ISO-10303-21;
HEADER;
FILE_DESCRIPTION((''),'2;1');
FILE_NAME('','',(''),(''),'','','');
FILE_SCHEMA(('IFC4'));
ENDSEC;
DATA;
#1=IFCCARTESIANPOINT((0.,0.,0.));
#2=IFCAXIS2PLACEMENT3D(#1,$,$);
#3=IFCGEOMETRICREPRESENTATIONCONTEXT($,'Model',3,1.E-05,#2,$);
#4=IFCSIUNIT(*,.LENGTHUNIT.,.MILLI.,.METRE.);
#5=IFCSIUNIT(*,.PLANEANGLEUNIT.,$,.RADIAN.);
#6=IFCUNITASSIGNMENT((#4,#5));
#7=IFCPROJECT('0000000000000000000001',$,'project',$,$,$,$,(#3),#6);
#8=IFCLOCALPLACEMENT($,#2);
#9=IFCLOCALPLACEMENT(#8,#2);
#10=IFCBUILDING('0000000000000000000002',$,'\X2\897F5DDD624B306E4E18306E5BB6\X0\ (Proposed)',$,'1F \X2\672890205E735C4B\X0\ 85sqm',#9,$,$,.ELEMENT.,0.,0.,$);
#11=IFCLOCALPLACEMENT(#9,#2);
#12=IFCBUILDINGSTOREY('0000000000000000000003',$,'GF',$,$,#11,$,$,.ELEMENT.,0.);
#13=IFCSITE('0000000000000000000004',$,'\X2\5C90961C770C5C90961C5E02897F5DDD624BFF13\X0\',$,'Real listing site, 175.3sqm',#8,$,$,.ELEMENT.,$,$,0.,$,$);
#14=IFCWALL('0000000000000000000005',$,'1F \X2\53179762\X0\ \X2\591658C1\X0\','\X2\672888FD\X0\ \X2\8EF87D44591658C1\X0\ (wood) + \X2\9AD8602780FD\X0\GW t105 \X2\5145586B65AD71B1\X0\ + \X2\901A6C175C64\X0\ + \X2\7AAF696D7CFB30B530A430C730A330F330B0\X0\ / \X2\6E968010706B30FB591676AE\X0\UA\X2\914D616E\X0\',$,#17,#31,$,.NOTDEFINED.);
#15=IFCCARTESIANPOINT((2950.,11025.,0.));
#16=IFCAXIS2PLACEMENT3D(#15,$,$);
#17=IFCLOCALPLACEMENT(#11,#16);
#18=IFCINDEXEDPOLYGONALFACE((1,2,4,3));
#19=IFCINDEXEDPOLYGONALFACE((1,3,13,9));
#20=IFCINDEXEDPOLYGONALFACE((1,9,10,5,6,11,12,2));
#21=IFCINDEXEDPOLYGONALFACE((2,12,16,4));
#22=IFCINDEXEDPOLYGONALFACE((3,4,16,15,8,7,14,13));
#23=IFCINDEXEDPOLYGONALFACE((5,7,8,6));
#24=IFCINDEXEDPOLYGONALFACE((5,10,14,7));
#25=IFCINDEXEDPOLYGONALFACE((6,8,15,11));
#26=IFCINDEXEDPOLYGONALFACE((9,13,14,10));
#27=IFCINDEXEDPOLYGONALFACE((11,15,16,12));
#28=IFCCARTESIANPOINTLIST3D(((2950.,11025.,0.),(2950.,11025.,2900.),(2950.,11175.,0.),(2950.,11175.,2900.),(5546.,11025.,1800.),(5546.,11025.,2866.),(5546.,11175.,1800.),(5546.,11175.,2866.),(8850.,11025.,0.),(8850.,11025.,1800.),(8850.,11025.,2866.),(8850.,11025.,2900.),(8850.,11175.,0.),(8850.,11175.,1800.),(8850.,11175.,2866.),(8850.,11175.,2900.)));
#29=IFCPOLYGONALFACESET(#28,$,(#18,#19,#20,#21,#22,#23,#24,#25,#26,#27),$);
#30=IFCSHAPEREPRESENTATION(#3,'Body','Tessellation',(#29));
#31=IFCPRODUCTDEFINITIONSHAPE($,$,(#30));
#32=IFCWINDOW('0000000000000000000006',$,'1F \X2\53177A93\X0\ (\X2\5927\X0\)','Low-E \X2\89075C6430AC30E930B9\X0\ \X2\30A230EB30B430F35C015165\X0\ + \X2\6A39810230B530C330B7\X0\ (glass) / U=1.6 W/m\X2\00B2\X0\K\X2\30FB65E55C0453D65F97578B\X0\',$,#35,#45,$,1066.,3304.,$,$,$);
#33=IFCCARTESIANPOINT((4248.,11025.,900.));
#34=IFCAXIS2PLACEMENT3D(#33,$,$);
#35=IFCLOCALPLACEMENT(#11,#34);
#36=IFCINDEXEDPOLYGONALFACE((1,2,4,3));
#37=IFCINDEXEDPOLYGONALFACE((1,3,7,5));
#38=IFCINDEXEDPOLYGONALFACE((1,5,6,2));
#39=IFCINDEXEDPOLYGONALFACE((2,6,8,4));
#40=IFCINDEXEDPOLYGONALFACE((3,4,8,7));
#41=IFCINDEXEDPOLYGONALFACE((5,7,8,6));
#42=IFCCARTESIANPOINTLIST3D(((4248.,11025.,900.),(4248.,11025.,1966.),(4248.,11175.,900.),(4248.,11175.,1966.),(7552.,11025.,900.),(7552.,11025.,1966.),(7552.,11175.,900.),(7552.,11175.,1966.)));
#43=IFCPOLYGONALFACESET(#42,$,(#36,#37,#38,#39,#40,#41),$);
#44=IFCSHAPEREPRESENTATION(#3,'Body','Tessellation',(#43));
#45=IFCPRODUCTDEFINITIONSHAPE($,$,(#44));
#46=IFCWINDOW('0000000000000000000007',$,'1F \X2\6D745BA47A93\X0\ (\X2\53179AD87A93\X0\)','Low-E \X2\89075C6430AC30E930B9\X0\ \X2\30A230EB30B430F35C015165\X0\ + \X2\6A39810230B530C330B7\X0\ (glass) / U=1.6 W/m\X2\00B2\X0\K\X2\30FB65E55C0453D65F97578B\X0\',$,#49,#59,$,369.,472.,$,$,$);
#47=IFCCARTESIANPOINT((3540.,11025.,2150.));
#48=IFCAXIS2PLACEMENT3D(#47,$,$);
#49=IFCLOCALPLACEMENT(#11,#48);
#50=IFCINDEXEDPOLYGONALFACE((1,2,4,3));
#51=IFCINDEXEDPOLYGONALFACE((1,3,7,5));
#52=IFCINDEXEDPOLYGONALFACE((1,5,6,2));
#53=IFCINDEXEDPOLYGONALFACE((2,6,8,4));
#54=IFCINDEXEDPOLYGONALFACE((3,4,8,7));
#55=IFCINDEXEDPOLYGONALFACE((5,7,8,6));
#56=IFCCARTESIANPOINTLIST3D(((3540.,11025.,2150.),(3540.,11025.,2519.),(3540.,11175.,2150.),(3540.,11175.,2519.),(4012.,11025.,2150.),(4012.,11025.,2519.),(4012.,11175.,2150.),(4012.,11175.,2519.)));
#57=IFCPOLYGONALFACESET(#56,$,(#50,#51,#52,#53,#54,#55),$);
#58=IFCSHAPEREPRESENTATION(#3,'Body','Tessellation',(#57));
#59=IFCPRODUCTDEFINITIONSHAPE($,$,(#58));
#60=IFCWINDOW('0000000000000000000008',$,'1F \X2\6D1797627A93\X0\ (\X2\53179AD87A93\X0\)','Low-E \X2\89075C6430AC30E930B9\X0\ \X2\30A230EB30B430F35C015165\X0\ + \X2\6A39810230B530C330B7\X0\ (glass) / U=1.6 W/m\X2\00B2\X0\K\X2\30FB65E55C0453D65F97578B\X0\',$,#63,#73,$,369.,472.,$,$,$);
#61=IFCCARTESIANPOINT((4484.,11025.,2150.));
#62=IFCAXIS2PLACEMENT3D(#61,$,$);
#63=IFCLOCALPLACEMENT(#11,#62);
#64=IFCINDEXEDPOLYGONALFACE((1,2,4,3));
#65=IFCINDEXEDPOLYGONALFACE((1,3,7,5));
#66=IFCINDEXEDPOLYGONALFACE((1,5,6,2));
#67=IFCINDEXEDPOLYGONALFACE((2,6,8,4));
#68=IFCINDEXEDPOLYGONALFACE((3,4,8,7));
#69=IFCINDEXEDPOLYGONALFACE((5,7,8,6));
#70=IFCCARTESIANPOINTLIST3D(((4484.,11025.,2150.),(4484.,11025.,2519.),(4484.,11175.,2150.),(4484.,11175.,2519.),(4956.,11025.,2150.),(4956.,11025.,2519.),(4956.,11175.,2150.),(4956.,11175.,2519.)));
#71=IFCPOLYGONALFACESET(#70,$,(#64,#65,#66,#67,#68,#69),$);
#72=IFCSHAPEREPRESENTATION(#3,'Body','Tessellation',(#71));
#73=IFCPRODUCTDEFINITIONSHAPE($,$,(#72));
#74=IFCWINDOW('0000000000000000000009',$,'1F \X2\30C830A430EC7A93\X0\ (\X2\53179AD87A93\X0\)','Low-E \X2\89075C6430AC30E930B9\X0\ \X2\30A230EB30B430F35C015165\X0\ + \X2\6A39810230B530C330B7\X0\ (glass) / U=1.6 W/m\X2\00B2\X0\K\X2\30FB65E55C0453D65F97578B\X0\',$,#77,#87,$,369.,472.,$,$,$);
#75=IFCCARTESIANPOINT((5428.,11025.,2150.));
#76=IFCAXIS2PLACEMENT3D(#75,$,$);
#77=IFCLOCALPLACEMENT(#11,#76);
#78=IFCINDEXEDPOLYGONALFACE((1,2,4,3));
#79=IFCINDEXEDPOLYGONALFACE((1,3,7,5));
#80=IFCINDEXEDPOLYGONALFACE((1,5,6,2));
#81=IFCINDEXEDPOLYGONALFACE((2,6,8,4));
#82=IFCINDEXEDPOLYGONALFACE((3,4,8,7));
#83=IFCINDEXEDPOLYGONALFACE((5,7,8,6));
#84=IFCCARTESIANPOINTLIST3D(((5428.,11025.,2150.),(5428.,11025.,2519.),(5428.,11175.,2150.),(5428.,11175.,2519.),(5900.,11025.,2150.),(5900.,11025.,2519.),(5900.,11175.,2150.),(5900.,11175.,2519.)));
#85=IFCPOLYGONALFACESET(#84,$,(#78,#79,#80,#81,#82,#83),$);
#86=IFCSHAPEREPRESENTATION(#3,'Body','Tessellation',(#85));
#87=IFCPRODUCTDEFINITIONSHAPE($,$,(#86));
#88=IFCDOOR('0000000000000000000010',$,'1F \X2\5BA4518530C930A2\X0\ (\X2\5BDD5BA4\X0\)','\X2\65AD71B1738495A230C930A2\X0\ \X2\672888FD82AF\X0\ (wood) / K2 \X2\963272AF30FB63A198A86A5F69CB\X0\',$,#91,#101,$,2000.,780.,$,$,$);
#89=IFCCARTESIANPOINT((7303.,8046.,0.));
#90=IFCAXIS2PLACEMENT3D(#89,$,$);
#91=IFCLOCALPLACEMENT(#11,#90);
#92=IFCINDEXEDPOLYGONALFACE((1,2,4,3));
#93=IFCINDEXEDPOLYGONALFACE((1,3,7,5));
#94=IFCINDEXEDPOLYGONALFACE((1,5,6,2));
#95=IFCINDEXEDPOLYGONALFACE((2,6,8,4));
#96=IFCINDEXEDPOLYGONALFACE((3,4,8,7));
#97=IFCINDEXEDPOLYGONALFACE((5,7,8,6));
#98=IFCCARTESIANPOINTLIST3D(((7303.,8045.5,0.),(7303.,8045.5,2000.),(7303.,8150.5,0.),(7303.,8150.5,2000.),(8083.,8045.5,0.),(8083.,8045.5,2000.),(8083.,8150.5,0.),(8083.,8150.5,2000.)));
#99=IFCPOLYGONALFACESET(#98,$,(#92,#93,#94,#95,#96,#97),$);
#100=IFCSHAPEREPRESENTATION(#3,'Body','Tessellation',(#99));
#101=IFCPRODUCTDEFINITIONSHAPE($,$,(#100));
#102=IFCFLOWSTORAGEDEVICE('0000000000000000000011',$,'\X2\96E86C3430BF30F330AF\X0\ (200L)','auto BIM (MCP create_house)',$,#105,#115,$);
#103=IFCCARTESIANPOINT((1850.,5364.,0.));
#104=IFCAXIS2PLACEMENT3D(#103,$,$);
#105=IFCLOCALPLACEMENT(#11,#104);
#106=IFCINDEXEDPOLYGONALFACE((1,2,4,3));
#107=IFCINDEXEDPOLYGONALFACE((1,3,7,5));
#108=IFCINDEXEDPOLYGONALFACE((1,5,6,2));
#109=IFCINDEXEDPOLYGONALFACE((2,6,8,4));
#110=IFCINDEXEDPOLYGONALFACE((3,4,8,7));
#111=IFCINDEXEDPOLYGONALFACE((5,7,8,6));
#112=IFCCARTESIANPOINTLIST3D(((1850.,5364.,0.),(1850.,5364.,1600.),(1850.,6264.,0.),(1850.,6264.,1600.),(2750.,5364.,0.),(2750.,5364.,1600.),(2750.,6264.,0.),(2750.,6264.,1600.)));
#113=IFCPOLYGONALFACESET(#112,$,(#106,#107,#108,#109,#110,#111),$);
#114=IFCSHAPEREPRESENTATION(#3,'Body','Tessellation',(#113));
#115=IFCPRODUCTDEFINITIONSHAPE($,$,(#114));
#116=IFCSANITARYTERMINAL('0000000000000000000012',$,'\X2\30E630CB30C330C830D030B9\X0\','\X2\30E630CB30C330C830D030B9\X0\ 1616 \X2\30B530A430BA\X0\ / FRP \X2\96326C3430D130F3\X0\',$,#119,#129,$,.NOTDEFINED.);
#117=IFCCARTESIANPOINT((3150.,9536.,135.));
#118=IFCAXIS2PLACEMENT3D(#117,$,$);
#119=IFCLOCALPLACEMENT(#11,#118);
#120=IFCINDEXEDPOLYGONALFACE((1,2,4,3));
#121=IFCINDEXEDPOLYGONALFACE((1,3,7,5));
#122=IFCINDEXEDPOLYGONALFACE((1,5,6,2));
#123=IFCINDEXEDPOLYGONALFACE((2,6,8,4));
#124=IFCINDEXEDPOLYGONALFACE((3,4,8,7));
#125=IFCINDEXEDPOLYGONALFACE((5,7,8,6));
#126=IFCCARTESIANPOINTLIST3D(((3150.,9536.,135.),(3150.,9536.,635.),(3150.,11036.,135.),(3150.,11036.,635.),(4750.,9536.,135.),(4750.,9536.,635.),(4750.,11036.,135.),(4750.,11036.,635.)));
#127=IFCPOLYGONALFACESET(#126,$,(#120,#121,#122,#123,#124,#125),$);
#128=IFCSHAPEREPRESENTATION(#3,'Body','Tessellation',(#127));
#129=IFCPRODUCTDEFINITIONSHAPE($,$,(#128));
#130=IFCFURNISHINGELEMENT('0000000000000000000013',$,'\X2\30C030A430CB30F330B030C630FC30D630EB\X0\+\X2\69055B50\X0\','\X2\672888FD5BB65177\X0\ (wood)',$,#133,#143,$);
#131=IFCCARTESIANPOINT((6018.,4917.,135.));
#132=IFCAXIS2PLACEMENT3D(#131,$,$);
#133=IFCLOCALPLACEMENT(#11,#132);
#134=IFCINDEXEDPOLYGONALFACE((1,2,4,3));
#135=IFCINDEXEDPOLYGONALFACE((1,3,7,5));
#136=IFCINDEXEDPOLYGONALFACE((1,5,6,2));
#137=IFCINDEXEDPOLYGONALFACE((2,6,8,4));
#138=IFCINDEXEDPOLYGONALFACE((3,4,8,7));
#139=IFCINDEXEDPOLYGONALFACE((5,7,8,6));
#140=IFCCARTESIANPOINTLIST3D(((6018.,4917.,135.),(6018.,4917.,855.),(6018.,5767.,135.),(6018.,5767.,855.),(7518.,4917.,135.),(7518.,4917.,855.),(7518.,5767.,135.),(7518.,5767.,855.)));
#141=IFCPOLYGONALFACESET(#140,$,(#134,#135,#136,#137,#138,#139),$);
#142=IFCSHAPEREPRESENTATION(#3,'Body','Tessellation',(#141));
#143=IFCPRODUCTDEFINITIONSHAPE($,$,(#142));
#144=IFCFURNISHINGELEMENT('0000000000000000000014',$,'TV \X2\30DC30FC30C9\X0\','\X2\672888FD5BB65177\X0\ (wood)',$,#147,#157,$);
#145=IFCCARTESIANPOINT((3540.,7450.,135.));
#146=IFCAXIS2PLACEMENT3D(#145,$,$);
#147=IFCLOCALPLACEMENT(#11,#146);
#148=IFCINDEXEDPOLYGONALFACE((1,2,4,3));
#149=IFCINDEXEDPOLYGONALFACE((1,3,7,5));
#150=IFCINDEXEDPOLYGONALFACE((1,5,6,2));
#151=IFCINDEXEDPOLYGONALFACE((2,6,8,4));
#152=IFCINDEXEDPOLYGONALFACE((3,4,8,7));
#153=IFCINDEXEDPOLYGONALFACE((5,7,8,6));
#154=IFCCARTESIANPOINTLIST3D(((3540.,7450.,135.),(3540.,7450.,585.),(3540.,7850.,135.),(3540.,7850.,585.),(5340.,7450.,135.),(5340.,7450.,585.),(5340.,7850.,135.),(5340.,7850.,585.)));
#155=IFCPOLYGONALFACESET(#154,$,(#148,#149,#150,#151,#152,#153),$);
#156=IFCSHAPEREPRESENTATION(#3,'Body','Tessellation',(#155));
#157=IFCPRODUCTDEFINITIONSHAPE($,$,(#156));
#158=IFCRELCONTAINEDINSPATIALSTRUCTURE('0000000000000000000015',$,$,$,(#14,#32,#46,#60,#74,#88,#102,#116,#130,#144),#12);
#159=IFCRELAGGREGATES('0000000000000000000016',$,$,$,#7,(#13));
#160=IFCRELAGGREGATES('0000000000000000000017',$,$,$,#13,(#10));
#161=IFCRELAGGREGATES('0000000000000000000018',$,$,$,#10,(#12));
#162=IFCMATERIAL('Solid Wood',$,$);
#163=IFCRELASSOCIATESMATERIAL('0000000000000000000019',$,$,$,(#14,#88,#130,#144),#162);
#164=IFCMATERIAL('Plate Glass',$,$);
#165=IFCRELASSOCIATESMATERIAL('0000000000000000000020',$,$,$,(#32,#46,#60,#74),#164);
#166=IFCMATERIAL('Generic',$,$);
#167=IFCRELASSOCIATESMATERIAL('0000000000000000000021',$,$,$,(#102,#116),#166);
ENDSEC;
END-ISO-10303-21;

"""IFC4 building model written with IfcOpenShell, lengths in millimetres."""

from ifc_helpers import new_model, si_unit, frame, frame_2d, origin, place, context, project, spatial, rectangle, extrude, material, element, fill, save


model = new_model("IFC4")

# Units and contexts
model_context = context("Model", 3, precision=1e-05, world=origin())
ifc_project = project(units=[si_unit("LENGTHUNIT", "METRE", prefix="MILLI"), si_unit("PLANEANGLEUNIT", "RADIAN")], contexts=[model_context])

# Site, building, storey
site_placement = place(None, origin())
site = spatial("IfcSite", under=ifc_project, at=site_placement, Name="岐阜県岐阜市西川手３", ObjectType="Real listing site, 175.3sqm", CompositionType="ELEMENT", RefElevation=0.0)
building_placement = place(site_placement, origin())
building = spatial("IfcBuilding", under=site, at=building_placement, Name="西川手の丘の家 (Proposed)", ObjectType="1F 木造平屋 85sqm", CompositionType="ELEMENT", ElevationOfRefHeight=0.0, ElevationOfTerrain=0.0)
storey_placement = place(building_placement, origin())
storey = spatial("IfcBuildingStorey", under=building, at=storey_placement, Name="GF", CompositionType="ELEMENT", Elevation=0.0)

# Wall, openings, windows
ifc_material_1 = material(Name="Solid Wood")
wall_1_placement = place(storey_placement, frame((2950.0, 11025.0, 0.0)))
wall_1 = element("IfcWall", 1, at=wall_1_placement, inside=storey, material=ifc_material_1, Name="1F 北面 外壁", Description="木製 軸組外壁 (wood) + 高性能GW t105 充填断熱 + 通気層 + 窯業系サイディング / 準耐火・外皮UA配慮", PredefinedType="NOTDEFINED", context=model_context, shape_type="SweptSolid", body=[
    extrude(rectangle(XDim=5900.0, YDim=150.0, at=frame_2d((2950.0, 75.0))), frame((2950.0, 11025.0, 0.0)), (0.0, 0.0, 1.0), 2900.0),
])
opening_1_placement = place(storey_placement, frame((4248.0, 11025.0, 900.0)))
opening_1 = element("IfcOpeningElement", 2, at=opening_1_placement, cuts=wall_1, PredefinedType="NOTDEFINED", context=model_context, shape_type="SweptSolid", body=[
    extrude(rectangle(XDim=3304.0, YDim=150.0, at=frame_2d((1652.0, 75.0))), frame((4248.0, 11025.0, 900.0)), (0.0, 0.0, 1.0), 1066.0),
])
opening_2_placement = place(storey_placement, frame((3540.0, 11025.0, 2150.0)))
opening_2 = element("IfcOpeningElement", 3, at=opening_2_placement, cuts=wall_1, PredefinedType="NOTDEFINED", context=model_context, shape_type="SweptSolid", body=[
    extrude(rectangle(XDim=472.0, YDim=150.0, at=frame_2d((236.0, 75.0))), frame((3540.0, 11025.0, 2150.0)), (0.0, 0.0, 1.0), 369.0),
])
opening_3_placement = place(storey_placement, frame((4484.0, 11025.0, 2150.0)))
opening_3 = element("IfcOpeningElement", 4, at=opening_3_placement, cuts=wall_1, PredefinedType="NOTDEFINED", context=model_context, shape_type="SweptSolid", body=[
    extrude(rectangle(XDim=472.0, YDim=150.0, at=frame_2d((236.0, 75.0))), frame((4484.0, 11025.0, 2150.0)), (0.0, 0.0, 1.0), 369.0),
])
opening_4_placement = place(storey_placement, frame((5428.0, 11025.0, 2150.0)))
opening_4 = element("IfcOpeningElement", 5, at=opening_4_placement, cuts=wall_1, PredefinedType="NOTDEFINED", context=model_context, shape_type="SweptSolid", body=[
    extrude(rectangle(XDim=472.0, YDim=150.0, at=frame_2d((236.0, 75.0))), frame((5428.0, 11025.0, 2150.0)), (0.0, 0.0, 1.0), 369.0),
])
ifc_material_2 = material(Name="Plate Glass")
window_1_placement = place(storey_placement, frame((4248.0, 11025.0, 900.0)))
window_1 = element("IfcWindow", 6, at=window_1_placement, inside=storey, material=ifc_material_2, Name="1F 北窓 (大)", Description="Low-E 複層ガラス アルゴン封入 + 樹脂サッシ (glass) / U=1.6 W/m²K・日射取得型", OverallHeight=1066.0, OverallWidth=3304.0, context=model_context, shape_type="SweptSolid", body=[
    extrude(rectangle(XDim=3304.0, YDim=150.0, at=frame_2d((1652.0, 75.0))), frame((4248.0, 11025.0, 900.0)), (0.0, 0.0, 1.0), 1066.0),
])
fill(opening_1, window_1)
window_2_placement = place(storey_placement, frame((3540.0, 11025.0, 2150.0)))
window_2 = element("IfcWindow", 7, at=window_2_placement, inside=storey, material=ifc_material_2, Name="1F 浴室窓 (北高窓)", Description="Low-E 複層ガラス アルゴン封入 + 樹脂サッシ (glass) / U=1.6 W/m²K・日射取得型", OverallHeight=369.0, OverallWidth=472.0, context=model_context, shape_type="SweptSolid", body=[
    extrude(rectangle(XDim=472.0, YDim=150.0, at=frame_2d((236.0, 75.0))), frame((3540.0, 11025.0, 2150.0)), (0.0, 0.0, 1.0), 369.0),
])
fill(opening_2, window_2)
window_3_placement = place(storey_placement, frame((4484.0, 11025.0, 2150.0)))
window_3 = element("IfcWindow", 8, at=window_3_placement, inside=storey, material=ifc_material_2, Name="1F 洗面窓 (北高窓)", Description="Low-E 複層ガラス アルゴン封入 + 樹脂サッシ (glass) / U=1.6 W/m²K・日射取得型", OverallHeight=369.0, OverallWidth=472.0, context=model_context, shape_type="SweptSolid", body=[
    extrude(rectangle(XDim=472.0, YDim=150.0, at=frame_2d((236.0, 75.0))), frame((4484.0, 11025.0, 2150.0)), (0.0, 0.0, 1.0), 369.0),
])
fill(opening_3, window_3)
window_4_placement = place(storey_placement, frame((5428.0, 11025.0, 2150.0)))
window_4 = element("IfcWindow", 9, at=window_4_placement, inside=storey, material=ifc_material_2, Name="1F トイレ窓 (北高窓)", Description="Low-E 複層ガラス アルゴン封入 + 樹脂サッシ (glass) / U=1.6 W/m²K・日射取得型", OverallHeight=369.0, OverallWidth=472.0, context=model_context, shape_type="SweptSolid", body=[
    extrude(rectangle(XDim=472.0, YDim=150.0, at=frame_2d((236.0, 75.0))), frame((5428.0, 11025.0, 2150.0)), (0.0, 0.0, 1.0), 369.0),
])
fill(opening_4, window_4)

# Door
door_1_placement = place(storey_placement, frame((7303.0, 8046.0, 0.0)))
element("IfcDoor", 10, at=door_1_placement, inside=storey, material=ifc_material_1, Name="1F 室内ドア (寝室)", Description="断熱玄関ドア 木製芯 (wood) / K2 防犯・採風機構", OverallHeight=2000.0, OverallWidth=780.0, context=model_context, shape_type="SweptSolid", body=[
    extrude(rectangle(XDim=780.0, YDim=105.0, at=frame_2d((390.0, 52.0))), frame((7303.0, 8046.0, 0.0)), (0.0, 0.0, 1.0), 2000.0),
])

# Flow storage device
ifc_material_3 = material(Name="Generic")
flow_storage_device_placement = place(storey_placement, frame((1850.0, 5364.0, 0.0)))
element("IfcFlowStorageDevice", 11, at=flow_storage_device_placement, inside=storey, material=ifc_material_3, Name="雨水タンク (200L)", Description="auto BIM (MCP create_house)", context=model_context, shape_type="SweptSolid", body=[
    extrude(rectangle(XDim=900.0, YDim=900.0, at=frame_2d((450.0, 450.0))), frame((1850.0, 5364.0, 0.0)), (0.0, 0.0, 1.0), 1600.0),
])

# Sanitary terminal
sanitary_terminal_placement = place(storey_placement, frame((3150.0, 9536.0, 135.0)))
element("IfcSanitaryTerminal", 12, at=sanitary_terminal_placement, inside=storey, material=ifc_material_3, Name="ユニットバス", Description="ユニットバス 1616 サイズ / FRP 防水パン", PredefinedType="NOTDEFINED", context=model_context, shape_type="SweptSolid", body=[
    extrude(rectangle(XDim=1600.0, YDim=1500.0, at=frame_2d((800.0, 750.0))), frame((3150.0, 9536.0, 135.0)), (0.0, 0.0, 1.0), 500.0),
])

# Furnishing elements
furnishing_1_placement = place(storey_placement, frame((6018.0, 4917.0, 135.0)))
element("IfcFurnishingElement", 13, at=furnishing_1_placement, inside=storey, material=ifc_material_1, Name="ダイニングテーブル+椅子", Description="木製家具 (wood)", context=model_context, shape_type="SweptSolid", body=[
    extrude(rectangle(XDim=1500.0, YDim=850.0, at=frame_2d((750.0, 425.0))), frame((6018.0, 4917.0, 135.0)), (0.0, 0.0, 1.0), 720.0),
])
furnishing_2_placement = place(storey_placement, frame((3540.0, 7450.0, 135.0)))
element("IfcFurnishingElement", 14, at=furnishing_2_placement, inside=storey, material=ifc_material_1, Name="TV ボード", Description="木製家具 (wood)", context=model_context, shape_type="SweptSolid", body=[
    extrude(rectangle(XDim=1800.0, YDim=400.0, at=frame_2d((900.0, 200.0))), frame((3540.0, 7450.0, 135.0)), (0.0, 0.0, 1.0), 450.0),
])

save(model, "model.ifc")
